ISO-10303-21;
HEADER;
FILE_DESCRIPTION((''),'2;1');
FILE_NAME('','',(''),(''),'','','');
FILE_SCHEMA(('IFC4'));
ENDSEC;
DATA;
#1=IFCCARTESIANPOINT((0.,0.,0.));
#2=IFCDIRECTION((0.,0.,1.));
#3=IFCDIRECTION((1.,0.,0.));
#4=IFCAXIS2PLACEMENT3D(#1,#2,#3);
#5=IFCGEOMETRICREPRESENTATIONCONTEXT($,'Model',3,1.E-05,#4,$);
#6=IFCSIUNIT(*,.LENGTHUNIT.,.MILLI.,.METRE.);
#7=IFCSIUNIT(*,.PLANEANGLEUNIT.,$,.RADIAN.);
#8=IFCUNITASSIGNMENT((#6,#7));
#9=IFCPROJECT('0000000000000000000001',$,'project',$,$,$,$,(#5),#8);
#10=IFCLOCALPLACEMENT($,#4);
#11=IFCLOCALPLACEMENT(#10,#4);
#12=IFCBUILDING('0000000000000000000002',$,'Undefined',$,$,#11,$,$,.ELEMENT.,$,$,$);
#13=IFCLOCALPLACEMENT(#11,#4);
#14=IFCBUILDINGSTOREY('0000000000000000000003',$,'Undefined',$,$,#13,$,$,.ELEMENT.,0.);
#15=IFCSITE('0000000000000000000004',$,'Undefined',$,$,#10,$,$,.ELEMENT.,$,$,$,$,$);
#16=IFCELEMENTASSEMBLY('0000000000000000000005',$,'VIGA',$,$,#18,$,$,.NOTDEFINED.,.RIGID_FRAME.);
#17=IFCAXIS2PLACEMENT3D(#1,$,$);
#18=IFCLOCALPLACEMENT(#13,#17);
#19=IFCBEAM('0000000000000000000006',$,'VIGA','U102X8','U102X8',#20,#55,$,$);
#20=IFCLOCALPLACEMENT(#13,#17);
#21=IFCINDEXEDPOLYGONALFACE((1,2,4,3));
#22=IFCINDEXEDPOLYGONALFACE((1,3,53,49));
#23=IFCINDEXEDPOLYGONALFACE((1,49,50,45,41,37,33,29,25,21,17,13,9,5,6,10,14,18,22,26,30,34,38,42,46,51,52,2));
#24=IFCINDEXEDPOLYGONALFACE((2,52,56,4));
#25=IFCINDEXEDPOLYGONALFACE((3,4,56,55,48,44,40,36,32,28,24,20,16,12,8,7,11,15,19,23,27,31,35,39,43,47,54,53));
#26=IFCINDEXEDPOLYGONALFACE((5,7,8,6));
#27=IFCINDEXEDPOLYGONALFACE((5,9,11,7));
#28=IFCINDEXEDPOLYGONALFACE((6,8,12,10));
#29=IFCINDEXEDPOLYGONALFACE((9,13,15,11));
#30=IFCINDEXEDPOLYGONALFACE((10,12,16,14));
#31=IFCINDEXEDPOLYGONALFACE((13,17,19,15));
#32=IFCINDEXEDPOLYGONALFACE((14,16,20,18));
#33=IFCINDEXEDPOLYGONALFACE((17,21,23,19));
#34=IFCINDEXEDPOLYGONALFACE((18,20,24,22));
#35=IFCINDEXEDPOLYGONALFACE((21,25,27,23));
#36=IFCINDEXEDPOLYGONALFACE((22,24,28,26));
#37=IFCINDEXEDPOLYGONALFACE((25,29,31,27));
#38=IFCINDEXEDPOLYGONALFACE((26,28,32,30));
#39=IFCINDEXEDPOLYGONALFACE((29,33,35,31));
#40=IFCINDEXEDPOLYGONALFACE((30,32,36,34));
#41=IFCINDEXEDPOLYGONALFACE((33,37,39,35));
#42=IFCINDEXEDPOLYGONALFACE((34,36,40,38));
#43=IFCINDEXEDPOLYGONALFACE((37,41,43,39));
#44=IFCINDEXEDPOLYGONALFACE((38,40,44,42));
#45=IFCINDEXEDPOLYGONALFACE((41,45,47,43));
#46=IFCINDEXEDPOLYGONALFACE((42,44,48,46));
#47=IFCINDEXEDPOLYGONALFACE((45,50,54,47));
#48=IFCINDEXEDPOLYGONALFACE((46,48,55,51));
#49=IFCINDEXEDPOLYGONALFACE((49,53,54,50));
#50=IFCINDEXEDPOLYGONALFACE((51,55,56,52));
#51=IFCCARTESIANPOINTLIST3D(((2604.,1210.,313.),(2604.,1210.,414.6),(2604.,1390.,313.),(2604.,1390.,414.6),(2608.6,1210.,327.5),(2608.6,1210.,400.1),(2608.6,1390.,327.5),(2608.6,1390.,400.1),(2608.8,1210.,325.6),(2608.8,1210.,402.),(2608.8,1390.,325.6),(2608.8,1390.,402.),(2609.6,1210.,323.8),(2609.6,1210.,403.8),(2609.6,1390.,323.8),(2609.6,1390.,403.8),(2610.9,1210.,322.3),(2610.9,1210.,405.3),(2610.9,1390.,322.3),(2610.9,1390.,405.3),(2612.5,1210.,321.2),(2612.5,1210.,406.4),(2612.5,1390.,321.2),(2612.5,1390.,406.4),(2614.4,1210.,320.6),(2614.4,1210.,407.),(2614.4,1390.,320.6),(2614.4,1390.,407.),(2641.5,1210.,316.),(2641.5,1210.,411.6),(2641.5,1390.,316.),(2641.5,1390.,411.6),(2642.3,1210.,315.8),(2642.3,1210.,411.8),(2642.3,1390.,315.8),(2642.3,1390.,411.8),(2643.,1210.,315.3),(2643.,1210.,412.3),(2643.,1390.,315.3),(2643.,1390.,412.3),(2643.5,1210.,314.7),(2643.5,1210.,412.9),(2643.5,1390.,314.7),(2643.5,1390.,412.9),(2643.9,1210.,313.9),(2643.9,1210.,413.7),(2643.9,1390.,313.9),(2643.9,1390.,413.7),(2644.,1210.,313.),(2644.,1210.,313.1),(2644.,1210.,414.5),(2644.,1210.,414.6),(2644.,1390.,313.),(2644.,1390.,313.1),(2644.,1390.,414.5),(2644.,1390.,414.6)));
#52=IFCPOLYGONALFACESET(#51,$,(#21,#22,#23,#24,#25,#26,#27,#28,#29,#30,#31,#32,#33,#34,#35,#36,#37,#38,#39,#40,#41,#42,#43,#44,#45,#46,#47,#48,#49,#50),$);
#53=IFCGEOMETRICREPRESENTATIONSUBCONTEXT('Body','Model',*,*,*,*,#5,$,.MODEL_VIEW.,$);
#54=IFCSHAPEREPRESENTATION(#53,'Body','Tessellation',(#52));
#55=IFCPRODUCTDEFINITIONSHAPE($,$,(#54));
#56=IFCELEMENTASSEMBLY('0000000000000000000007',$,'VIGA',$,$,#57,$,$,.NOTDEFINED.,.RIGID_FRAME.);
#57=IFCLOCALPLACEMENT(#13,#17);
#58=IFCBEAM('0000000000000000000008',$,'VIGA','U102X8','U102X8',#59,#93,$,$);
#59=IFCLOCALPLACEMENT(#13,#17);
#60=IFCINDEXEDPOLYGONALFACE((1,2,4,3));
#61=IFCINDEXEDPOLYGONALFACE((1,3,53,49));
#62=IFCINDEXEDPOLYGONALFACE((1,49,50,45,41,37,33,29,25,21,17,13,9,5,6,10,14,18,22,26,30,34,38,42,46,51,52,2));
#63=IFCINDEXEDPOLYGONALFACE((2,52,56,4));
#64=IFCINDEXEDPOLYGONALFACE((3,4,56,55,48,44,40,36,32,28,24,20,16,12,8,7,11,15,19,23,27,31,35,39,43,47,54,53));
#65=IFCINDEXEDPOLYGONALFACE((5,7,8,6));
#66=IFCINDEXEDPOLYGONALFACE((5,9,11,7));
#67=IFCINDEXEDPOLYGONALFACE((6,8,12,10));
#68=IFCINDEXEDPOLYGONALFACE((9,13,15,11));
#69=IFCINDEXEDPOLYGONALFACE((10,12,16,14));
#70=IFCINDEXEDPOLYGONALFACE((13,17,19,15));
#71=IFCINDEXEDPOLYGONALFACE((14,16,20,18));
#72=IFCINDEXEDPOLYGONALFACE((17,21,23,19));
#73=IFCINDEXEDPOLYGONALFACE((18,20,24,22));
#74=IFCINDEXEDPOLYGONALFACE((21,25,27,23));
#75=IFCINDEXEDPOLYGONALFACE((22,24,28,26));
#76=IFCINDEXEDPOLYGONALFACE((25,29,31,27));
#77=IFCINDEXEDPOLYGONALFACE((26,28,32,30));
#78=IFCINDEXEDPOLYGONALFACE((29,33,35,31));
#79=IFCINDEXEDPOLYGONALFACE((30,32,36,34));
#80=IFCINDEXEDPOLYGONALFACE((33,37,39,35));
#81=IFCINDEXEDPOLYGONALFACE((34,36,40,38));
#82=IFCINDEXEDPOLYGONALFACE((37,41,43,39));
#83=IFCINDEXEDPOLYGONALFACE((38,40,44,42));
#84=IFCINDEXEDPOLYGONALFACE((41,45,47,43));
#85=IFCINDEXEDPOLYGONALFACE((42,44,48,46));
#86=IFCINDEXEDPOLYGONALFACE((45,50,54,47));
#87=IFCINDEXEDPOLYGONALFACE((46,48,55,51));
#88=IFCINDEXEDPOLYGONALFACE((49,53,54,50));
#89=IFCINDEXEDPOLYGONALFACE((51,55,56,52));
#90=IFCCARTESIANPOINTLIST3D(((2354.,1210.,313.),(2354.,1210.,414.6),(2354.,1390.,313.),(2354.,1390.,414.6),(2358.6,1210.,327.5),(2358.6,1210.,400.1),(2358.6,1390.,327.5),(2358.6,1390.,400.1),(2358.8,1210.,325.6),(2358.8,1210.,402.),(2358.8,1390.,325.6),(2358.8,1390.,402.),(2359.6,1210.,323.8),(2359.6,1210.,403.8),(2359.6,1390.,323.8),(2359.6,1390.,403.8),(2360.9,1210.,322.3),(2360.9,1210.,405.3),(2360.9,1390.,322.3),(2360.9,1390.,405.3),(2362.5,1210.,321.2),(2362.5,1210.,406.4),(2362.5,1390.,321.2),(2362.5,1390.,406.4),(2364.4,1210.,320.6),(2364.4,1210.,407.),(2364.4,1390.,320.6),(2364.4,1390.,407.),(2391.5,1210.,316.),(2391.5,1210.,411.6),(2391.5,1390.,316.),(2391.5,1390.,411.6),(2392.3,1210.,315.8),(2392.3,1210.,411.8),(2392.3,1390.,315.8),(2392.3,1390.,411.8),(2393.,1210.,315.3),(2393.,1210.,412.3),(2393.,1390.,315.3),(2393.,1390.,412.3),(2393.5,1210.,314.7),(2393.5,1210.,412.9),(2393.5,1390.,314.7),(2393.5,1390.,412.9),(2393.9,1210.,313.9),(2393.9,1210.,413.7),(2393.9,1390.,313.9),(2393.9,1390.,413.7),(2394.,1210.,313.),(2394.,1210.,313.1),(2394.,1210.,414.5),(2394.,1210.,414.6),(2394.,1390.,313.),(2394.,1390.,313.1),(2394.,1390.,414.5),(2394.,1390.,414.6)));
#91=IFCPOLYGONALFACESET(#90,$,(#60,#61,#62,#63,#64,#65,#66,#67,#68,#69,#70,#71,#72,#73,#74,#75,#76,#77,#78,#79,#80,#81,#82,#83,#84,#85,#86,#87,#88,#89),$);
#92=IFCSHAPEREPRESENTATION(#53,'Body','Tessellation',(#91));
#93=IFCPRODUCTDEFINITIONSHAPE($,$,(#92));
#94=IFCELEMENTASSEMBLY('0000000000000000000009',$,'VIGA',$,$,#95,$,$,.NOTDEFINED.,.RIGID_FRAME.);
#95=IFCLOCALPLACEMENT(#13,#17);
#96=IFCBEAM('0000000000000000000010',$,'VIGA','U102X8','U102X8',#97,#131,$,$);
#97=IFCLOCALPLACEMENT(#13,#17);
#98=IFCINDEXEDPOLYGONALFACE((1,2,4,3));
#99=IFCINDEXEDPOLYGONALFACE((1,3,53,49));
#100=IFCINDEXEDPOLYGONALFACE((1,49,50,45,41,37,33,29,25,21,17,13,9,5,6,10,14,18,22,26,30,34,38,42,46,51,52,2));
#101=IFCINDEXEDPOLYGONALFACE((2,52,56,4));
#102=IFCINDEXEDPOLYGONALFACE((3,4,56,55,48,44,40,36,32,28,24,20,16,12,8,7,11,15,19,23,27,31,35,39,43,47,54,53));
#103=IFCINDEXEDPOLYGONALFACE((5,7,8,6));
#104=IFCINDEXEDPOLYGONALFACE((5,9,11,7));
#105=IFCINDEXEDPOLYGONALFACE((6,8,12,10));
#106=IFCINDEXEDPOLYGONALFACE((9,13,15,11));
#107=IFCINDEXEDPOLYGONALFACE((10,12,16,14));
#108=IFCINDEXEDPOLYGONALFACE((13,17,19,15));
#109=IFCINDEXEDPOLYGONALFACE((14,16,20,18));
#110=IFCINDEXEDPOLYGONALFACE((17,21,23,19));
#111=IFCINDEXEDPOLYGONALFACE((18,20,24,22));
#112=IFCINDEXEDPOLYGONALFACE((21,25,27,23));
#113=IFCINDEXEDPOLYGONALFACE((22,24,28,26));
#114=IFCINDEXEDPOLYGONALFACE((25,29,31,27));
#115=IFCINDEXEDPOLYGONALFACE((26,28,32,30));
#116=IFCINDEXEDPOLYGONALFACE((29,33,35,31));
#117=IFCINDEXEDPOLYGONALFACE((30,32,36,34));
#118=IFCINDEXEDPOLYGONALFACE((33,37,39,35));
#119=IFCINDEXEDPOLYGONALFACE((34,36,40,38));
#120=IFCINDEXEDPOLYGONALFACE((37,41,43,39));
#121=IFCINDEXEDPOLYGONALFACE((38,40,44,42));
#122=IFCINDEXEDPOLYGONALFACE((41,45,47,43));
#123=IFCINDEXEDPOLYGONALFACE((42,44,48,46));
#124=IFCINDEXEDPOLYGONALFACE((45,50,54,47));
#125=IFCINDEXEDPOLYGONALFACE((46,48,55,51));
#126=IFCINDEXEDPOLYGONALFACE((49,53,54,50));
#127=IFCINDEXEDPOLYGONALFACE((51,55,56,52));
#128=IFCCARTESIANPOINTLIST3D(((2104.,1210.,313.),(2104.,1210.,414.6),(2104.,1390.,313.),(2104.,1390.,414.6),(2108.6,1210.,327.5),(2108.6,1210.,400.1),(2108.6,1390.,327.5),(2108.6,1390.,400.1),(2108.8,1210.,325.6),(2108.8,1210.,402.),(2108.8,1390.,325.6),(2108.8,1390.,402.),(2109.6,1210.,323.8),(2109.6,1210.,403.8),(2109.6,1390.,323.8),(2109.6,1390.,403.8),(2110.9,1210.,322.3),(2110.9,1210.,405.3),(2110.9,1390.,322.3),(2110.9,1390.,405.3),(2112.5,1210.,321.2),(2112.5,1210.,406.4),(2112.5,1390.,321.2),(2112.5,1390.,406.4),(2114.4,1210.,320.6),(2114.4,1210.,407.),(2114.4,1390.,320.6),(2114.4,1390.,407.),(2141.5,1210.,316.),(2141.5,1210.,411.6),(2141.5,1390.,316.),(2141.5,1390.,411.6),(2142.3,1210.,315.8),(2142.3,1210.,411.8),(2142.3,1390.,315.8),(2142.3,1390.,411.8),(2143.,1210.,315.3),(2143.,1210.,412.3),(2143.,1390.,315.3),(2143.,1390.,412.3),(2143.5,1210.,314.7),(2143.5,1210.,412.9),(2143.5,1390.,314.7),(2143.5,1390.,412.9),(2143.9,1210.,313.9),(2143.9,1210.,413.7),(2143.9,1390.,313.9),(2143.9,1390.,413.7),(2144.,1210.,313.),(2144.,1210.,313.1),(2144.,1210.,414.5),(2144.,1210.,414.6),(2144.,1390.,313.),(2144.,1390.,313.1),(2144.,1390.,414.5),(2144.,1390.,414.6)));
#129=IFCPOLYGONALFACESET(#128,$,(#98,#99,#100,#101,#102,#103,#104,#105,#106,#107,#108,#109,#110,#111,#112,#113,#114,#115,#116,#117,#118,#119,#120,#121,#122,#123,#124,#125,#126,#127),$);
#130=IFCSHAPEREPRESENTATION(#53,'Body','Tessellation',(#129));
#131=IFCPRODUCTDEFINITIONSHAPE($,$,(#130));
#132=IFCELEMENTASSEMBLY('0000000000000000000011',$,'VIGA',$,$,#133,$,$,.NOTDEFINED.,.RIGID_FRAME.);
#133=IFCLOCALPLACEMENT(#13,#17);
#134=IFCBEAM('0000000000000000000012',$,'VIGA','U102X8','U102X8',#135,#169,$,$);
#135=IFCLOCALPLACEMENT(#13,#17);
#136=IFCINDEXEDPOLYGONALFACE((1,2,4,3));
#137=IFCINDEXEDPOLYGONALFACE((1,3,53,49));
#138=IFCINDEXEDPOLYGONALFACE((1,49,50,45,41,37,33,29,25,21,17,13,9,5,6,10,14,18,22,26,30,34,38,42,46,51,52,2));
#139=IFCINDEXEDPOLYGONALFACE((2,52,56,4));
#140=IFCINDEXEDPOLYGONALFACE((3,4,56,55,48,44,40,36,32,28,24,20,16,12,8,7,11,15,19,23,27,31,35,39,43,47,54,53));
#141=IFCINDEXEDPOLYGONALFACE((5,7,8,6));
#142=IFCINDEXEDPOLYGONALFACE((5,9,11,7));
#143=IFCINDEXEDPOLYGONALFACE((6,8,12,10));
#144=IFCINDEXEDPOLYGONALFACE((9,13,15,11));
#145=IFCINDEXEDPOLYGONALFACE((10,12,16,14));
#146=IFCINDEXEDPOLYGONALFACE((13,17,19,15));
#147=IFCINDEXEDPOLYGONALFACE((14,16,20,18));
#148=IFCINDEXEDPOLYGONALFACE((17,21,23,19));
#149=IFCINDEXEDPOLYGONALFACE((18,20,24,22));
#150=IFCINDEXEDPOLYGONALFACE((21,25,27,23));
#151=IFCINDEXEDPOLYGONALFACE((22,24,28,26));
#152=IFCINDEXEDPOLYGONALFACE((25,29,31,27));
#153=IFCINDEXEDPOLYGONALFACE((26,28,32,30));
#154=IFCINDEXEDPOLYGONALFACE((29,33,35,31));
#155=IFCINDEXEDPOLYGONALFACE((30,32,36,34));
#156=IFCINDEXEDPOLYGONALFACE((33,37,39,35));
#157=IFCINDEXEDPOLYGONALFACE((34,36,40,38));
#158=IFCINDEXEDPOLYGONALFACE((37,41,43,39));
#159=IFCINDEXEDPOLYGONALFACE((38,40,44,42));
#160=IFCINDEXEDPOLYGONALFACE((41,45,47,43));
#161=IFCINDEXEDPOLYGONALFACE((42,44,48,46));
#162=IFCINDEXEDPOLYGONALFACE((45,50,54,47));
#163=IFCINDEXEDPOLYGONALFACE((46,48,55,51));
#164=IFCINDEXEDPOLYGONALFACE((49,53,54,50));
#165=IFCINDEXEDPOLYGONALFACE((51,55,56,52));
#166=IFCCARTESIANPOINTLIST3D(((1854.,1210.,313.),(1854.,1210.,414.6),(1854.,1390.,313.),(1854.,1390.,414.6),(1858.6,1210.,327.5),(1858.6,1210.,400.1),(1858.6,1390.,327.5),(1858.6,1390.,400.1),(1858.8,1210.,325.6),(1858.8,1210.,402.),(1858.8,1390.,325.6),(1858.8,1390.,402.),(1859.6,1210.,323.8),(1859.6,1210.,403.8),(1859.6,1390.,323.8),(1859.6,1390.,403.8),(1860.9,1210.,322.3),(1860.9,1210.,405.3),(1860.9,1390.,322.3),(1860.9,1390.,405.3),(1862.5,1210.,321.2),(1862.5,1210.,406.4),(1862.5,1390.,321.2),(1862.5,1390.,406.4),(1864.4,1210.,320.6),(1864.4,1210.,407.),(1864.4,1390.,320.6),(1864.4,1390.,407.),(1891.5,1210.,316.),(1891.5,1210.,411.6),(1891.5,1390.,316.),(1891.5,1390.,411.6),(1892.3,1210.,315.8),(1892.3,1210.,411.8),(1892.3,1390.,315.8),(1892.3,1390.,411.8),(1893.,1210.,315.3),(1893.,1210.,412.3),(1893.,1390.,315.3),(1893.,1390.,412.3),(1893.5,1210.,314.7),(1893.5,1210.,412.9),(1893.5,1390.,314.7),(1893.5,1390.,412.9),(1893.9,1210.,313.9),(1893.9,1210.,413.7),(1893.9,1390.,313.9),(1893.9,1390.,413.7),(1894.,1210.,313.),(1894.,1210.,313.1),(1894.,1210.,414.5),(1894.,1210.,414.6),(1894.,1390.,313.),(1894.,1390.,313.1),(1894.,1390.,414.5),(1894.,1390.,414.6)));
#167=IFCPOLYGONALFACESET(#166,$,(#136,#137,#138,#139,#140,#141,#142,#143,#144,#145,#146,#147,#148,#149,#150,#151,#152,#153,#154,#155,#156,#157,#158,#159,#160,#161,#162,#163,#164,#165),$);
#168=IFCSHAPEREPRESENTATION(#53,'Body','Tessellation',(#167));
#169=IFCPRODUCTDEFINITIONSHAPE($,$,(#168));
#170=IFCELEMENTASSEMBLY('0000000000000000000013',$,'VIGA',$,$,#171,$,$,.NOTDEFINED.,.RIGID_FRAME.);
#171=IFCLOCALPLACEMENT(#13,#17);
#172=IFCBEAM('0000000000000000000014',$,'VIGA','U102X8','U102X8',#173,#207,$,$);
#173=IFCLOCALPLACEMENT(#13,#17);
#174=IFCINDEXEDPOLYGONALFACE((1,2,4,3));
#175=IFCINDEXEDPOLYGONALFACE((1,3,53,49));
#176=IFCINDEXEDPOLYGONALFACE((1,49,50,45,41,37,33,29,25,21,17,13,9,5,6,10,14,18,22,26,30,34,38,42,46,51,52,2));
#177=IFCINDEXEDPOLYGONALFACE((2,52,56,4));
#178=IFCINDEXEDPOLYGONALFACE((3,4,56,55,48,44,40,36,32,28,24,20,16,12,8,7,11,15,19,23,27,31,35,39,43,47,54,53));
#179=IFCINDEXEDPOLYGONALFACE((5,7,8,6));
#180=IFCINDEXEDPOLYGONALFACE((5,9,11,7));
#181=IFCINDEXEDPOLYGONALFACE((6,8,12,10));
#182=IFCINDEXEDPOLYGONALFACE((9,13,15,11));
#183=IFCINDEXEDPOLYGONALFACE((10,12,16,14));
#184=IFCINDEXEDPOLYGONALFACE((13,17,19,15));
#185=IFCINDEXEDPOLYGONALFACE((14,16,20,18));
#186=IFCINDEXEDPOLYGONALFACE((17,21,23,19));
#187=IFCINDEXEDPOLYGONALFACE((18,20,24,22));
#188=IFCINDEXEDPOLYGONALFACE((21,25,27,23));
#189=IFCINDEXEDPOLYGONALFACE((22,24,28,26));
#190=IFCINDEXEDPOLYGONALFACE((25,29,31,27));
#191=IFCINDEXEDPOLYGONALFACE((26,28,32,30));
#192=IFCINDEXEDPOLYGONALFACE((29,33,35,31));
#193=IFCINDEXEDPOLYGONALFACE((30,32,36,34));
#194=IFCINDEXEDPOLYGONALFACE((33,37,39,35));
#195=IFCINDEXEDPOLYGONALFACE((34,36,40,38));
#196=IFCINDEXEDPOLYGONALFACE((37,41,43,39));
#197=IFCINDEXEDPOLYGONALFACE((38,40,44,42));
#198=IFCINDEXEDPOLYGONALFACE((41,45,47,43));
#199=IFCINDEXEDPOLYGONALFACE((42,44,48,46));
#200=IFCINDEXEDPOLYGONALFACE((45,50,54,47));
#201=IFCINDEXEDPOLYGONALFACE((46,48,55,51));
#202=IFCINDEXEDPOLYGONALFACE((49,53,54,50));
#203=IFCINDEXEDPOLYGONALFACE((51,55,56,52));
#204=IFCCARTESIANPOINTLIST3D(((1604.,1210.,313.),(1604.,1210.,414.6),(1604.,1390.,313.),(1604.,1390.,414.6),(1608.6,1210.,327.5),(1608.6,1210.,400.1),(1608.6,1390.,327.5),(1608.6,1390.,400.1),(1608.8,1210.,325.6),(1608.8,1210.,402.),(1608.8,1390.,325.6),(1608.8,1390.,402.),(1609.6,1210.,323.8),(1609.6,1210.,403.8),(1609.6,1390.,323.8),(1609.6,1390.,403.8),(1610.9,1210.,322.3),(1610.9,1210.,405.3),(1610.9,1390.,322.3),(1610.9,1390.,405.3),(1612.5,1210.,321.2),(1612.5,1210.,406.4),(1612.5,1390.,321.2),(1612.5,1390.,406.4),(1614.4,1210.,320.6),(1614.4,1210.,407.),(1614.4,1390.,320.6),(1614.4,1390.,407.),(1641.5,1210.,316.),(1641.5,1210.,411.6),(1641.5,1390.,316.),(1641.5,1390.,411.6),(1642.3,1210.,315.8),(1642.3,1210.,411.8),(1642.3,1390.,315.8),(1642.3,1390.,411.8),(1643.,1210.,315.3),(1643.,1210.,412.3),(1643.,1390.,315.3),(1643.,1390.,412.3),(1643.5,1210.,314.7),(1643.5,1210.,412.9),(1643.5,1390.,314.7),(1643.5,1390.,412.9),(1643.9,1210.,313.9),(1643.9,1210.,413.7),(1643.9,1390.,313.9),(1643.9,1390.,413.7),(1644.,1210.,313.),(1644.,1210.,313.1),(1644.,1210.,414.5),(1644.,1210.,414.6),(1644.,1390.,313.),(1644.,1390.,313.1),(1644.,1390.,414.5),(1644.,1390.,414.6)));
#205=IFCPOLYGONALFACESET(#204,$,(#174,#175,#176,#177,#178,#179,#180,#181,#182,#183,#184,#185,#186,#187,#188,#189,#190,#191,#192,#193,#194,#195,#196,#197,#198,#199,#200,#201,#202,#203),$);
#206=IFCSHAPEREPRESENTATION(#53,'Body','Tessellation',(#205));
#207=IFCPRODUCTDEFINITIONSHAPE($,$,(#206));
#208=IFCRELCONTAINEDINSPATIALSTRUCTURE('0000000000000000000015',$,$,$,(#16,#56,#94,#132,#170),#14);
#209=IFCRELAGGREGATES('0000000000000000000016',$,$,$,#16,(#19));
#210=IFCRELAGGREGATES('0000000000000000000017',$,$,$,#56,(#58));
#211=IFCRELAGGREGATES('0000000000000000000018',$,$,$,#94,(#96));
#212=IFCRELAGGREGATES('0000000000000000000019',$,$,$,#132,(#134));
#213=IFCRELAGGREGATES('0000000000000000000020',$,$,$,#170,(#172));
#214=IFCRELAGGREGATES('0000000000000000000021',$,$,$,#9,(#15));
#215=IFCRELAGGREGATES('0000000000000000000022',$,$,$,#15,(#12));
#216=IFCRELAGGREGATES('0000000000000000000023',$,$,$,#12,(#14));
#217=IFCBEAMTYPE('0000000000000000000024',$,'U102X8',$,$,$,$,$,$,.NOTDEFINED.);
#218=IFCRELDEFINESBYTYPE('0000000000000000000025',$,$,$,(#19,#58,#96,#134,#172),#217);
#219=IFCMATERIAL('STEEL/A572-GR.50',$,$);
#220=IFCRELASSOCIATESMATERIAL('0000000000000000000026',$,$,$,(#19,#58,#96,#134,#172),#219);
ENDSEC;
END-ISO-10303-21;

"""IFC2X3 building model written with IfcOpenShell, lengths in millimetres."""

from ifc_helpers import new_model, si_unit, frame, origin_with_axes, origin_2d_with_axis, place, context, subcontext, project, spatial, u_section, extrude, material, type_object, element, aggregate, save


model = new_model("IFC2X3")

# Units and contexts
model_context = context("Model", 3, precision=1e-05, world=origin_with_axes())
body_context = subcontext(model_context, "Body", "Model", "MODEL_VIEW")
ifc_project = project(units=[si_unit("LENGTHUNIT", "METRE", prefix="MILLI"), si_unit("PLANEANGLEUNIT", "RADIAN")], contexts=[model_context])

# Site, building, storey
site_placement = place(None, origin_with_axes())
site = spatial("IfcSite", under=ifc_project, at=site_placement, Name="Undefined", CompositionType="ELEMENT")
building_placement = place(site_placement, origin_with_axes())
building = spatial("IfcBuilding", under=site, at=building_placement, Name="Undefined", CompositionType="ELEMENT")
storey_placement = place(building_placement, origin_with_axes())
storey = spatial("IfcBuildingStorey", under=building, at=storey_placement, Name="Undefined", CompositionType="ELEMENT", Elevation=0.0)

# Element assemblies, beams
ifc_material = material(Name="STEEL/A572-GR.50")
beam_type = type_object("IfcBeamType", Name="U102X8", PredefinedType="NOTDEFINED")
assembly_1_placement = place(storey_placement, origin_with_axes())
assembly_1 = element("IfcElementAssembly", 1, at=assembly_1_placement, inside=storey, Name="VIGA", AssemblyPlace="NOTDEFINED", PredefinedType="RIGID_FRAME")
beam_1_placement = place(assembly_1_placement, frame((2624.0, 1210.0, 363.8), z_axis=(0.0, 0.0, 1.0), x_axis=(0.0, 1.0, 0.0)))
beam_1 = element("IfcBeam", 2, at=beam_1_placement, type_object=beam_type, material=ifc_material, Name="VIGA", Description="U102X8", ObjectType="U102X8", context=body_context, shape_type="SweptSolid", body=[
    extrude(u_section(Depth=101.6, FlangeWidth=40.0, WebThickness=4.6, FlangeThickness=6.0, FilletRadius=7.0, EdgeRadius=3.0, FlangeSlope=0.16839, at=origin_2d_with_axis()), frame((180.0, 0.0, 0.0), z_axis=(-1.0, 0.0, 0.0), x_axis=(0.0, -1.0, 0.0)), (0.0, 0.0, 1.0), 180.0),
])
aggregate(assembly_1, [beam_1])
assembly_2_placement = place(storey_placement, origin_with_axes())
assembly_2 = element("IfcElementAssembly", 3, at=assembly_2_placement, inside=storey, Name="VIGA", AssemblyPlace="NOTDEFINED", PredefinedType="RIGID_FRAME")
beam_2_placement = place(assembly_2_placement, frame((2374.0, 1210.0, 363.8), z_axis=(0.0, 0.0, 1.0), x_axis=(0.0, 1.0, 0.0)))
beam_2 = element("IfcBeam", 4, at=beam_2_placement, type_object=beam_type, material=ifc_material, Name="VIGA", Description="U102X8", ObjectType="U102X8", context=body_context, shape_type="SweptSolid", body=[
    extrude(u_section(Depth=101.6, FlangeWidth=40.0, WebThickness=4.6, FlangeThickness=6.0, FilletRadius=7.0, EdgeRadius=3.0, FlangeSlope=0.16839, at=origin_2d_with_axis()), frame((180.0, 0.0, 0.0), z_axis=(-1.0, 0.0, 0.0), x_axis=(0.0, -1.0, 0.0)), (0.0, 0.0, 1.0), 180.0),
])
aggregate(assembly_2, [beam_2])
assembly_3_placement = place(storey_placement, origin_with_axes())
assembly_3 = element("IfcElementAssembly", 5, at=assembly_3_placement, inside=storey, Name="VIGA", AssemblyPlace="NOTDEFINED", PredefinedType="RIGID_FRAME")
beam_3_placement = place(assembly_3_placement, frame((2124.0, 1210.0, 363.8), z_axis=(0.0, 0.0, 1.0), x_axis=(0.0, 1.0, 0.0)))
beam_3 = element("IfcBeam", 6, at=beam_3_placement, type_object=beam_type, material=ifc_material, Name="VIGA", Description="U102X8", ObjectType="U102X8", context=body_context, shape_type="SweptSolid", body=[
    extrude(u_section(Depth=101.6, FlangeWidth=40.0, WebThickness=4.6, FlangeThickness=6.0, FilletRadius=7.0, EdgeRadius=3.0, FlangeSlope=0.16839, at=origin_2d_with_axis()), frame((180.0, 0.0, 0.0), z_axis=(-1.0, 0.0, 0.0), x_axis=(0.0, -1.0, 0.0)), (0.0, 0.0, 1.0), 180.0),
])
aggregate(assembly_3, [beam_3])
assembly_4_placement = place(storey_placement, origin_with_axes())
assembly_4 = element("IfcElementAssembly", 7, at=assembly_4_placement, inside=storey, Name="VIGA", AssemblyPlace="NOTDEFINED", PredefinedType="RIGID_FRAME")
beam_4_placement = place(assembly_4_placement, frame((1874.0, 1210.0, 363.8), z_axis=(0.0, 0.0, 1.0), x_axis=(0.0, 1.0, 0.0)))
beam_4 = element("IfcBeam", 8, at=beam_4_placement, type_object=beam_type, material=ifc_material, Name="VIGA", Description="U102X8", ObjectType="U102X8", context=body_context, shape_type="SweptSolid", body=[
    extrude(u_section(Depth=101.6, FlangeWidth=40.0, WebThickness=4.6, FlangeThickness=6.0, FilletRadius=7.0, EdgeRadius=3.0, FlangeSlope=0.16839, at=origin_2d_with_axis()), frame((180.0, 0.0, 0.0), z_axis=(-1.0, 0.0, 0.0), x_axis=(0.0, -1.0, 0.0)), (0.0, 0.0, 1.0), 180.0),
])
aggregate(assembly_4, [beam_4])
assembly_5_placement = place(storey_placement, origin_with_axes())
assembly_5 = element("IfcElementAssembly", 9, at=assembly_5_placement, inside=storey, Name="VIGA", AssemblyPlace="NOTDEFINED", PredefinedType="RIGID_FRAME")
beam_5_placement = place(assembly_5_placement, frame((1624.0, 1210.0, 363.8), z_axis=(0.0, 0.0, 1.0), x_axis=(0.0, 1.0, 0.0)))
beam_5 = element("IfcBeam", 10, at=beam_5_placement, type_object=beam_type, material=ifc_material, Name="VIGA", Description="U102X8", ObjectType="U102X8", context=body_context, shape_type="SweptSolid", body=[
    extrude(u_section(Depth=101.6, FlangeWidth=40.0, WebThickness=4.6, FlangeThickness=6.0, FilletRadius=7.0, EdgeRadius=3.0, FlangeSlope=0.16839, at=origin_2d_with_axis()), frame((180.0, 0.0, 0.0), z_axis=(-1.0, 0.0, 0.0), x_axis=(0.0, -1.0, 0.0)), (0.0, 0.0, 1.0), 180.0),
])
aggregate(assembly_5, [beam_5])

save(model, "model.ifc")
